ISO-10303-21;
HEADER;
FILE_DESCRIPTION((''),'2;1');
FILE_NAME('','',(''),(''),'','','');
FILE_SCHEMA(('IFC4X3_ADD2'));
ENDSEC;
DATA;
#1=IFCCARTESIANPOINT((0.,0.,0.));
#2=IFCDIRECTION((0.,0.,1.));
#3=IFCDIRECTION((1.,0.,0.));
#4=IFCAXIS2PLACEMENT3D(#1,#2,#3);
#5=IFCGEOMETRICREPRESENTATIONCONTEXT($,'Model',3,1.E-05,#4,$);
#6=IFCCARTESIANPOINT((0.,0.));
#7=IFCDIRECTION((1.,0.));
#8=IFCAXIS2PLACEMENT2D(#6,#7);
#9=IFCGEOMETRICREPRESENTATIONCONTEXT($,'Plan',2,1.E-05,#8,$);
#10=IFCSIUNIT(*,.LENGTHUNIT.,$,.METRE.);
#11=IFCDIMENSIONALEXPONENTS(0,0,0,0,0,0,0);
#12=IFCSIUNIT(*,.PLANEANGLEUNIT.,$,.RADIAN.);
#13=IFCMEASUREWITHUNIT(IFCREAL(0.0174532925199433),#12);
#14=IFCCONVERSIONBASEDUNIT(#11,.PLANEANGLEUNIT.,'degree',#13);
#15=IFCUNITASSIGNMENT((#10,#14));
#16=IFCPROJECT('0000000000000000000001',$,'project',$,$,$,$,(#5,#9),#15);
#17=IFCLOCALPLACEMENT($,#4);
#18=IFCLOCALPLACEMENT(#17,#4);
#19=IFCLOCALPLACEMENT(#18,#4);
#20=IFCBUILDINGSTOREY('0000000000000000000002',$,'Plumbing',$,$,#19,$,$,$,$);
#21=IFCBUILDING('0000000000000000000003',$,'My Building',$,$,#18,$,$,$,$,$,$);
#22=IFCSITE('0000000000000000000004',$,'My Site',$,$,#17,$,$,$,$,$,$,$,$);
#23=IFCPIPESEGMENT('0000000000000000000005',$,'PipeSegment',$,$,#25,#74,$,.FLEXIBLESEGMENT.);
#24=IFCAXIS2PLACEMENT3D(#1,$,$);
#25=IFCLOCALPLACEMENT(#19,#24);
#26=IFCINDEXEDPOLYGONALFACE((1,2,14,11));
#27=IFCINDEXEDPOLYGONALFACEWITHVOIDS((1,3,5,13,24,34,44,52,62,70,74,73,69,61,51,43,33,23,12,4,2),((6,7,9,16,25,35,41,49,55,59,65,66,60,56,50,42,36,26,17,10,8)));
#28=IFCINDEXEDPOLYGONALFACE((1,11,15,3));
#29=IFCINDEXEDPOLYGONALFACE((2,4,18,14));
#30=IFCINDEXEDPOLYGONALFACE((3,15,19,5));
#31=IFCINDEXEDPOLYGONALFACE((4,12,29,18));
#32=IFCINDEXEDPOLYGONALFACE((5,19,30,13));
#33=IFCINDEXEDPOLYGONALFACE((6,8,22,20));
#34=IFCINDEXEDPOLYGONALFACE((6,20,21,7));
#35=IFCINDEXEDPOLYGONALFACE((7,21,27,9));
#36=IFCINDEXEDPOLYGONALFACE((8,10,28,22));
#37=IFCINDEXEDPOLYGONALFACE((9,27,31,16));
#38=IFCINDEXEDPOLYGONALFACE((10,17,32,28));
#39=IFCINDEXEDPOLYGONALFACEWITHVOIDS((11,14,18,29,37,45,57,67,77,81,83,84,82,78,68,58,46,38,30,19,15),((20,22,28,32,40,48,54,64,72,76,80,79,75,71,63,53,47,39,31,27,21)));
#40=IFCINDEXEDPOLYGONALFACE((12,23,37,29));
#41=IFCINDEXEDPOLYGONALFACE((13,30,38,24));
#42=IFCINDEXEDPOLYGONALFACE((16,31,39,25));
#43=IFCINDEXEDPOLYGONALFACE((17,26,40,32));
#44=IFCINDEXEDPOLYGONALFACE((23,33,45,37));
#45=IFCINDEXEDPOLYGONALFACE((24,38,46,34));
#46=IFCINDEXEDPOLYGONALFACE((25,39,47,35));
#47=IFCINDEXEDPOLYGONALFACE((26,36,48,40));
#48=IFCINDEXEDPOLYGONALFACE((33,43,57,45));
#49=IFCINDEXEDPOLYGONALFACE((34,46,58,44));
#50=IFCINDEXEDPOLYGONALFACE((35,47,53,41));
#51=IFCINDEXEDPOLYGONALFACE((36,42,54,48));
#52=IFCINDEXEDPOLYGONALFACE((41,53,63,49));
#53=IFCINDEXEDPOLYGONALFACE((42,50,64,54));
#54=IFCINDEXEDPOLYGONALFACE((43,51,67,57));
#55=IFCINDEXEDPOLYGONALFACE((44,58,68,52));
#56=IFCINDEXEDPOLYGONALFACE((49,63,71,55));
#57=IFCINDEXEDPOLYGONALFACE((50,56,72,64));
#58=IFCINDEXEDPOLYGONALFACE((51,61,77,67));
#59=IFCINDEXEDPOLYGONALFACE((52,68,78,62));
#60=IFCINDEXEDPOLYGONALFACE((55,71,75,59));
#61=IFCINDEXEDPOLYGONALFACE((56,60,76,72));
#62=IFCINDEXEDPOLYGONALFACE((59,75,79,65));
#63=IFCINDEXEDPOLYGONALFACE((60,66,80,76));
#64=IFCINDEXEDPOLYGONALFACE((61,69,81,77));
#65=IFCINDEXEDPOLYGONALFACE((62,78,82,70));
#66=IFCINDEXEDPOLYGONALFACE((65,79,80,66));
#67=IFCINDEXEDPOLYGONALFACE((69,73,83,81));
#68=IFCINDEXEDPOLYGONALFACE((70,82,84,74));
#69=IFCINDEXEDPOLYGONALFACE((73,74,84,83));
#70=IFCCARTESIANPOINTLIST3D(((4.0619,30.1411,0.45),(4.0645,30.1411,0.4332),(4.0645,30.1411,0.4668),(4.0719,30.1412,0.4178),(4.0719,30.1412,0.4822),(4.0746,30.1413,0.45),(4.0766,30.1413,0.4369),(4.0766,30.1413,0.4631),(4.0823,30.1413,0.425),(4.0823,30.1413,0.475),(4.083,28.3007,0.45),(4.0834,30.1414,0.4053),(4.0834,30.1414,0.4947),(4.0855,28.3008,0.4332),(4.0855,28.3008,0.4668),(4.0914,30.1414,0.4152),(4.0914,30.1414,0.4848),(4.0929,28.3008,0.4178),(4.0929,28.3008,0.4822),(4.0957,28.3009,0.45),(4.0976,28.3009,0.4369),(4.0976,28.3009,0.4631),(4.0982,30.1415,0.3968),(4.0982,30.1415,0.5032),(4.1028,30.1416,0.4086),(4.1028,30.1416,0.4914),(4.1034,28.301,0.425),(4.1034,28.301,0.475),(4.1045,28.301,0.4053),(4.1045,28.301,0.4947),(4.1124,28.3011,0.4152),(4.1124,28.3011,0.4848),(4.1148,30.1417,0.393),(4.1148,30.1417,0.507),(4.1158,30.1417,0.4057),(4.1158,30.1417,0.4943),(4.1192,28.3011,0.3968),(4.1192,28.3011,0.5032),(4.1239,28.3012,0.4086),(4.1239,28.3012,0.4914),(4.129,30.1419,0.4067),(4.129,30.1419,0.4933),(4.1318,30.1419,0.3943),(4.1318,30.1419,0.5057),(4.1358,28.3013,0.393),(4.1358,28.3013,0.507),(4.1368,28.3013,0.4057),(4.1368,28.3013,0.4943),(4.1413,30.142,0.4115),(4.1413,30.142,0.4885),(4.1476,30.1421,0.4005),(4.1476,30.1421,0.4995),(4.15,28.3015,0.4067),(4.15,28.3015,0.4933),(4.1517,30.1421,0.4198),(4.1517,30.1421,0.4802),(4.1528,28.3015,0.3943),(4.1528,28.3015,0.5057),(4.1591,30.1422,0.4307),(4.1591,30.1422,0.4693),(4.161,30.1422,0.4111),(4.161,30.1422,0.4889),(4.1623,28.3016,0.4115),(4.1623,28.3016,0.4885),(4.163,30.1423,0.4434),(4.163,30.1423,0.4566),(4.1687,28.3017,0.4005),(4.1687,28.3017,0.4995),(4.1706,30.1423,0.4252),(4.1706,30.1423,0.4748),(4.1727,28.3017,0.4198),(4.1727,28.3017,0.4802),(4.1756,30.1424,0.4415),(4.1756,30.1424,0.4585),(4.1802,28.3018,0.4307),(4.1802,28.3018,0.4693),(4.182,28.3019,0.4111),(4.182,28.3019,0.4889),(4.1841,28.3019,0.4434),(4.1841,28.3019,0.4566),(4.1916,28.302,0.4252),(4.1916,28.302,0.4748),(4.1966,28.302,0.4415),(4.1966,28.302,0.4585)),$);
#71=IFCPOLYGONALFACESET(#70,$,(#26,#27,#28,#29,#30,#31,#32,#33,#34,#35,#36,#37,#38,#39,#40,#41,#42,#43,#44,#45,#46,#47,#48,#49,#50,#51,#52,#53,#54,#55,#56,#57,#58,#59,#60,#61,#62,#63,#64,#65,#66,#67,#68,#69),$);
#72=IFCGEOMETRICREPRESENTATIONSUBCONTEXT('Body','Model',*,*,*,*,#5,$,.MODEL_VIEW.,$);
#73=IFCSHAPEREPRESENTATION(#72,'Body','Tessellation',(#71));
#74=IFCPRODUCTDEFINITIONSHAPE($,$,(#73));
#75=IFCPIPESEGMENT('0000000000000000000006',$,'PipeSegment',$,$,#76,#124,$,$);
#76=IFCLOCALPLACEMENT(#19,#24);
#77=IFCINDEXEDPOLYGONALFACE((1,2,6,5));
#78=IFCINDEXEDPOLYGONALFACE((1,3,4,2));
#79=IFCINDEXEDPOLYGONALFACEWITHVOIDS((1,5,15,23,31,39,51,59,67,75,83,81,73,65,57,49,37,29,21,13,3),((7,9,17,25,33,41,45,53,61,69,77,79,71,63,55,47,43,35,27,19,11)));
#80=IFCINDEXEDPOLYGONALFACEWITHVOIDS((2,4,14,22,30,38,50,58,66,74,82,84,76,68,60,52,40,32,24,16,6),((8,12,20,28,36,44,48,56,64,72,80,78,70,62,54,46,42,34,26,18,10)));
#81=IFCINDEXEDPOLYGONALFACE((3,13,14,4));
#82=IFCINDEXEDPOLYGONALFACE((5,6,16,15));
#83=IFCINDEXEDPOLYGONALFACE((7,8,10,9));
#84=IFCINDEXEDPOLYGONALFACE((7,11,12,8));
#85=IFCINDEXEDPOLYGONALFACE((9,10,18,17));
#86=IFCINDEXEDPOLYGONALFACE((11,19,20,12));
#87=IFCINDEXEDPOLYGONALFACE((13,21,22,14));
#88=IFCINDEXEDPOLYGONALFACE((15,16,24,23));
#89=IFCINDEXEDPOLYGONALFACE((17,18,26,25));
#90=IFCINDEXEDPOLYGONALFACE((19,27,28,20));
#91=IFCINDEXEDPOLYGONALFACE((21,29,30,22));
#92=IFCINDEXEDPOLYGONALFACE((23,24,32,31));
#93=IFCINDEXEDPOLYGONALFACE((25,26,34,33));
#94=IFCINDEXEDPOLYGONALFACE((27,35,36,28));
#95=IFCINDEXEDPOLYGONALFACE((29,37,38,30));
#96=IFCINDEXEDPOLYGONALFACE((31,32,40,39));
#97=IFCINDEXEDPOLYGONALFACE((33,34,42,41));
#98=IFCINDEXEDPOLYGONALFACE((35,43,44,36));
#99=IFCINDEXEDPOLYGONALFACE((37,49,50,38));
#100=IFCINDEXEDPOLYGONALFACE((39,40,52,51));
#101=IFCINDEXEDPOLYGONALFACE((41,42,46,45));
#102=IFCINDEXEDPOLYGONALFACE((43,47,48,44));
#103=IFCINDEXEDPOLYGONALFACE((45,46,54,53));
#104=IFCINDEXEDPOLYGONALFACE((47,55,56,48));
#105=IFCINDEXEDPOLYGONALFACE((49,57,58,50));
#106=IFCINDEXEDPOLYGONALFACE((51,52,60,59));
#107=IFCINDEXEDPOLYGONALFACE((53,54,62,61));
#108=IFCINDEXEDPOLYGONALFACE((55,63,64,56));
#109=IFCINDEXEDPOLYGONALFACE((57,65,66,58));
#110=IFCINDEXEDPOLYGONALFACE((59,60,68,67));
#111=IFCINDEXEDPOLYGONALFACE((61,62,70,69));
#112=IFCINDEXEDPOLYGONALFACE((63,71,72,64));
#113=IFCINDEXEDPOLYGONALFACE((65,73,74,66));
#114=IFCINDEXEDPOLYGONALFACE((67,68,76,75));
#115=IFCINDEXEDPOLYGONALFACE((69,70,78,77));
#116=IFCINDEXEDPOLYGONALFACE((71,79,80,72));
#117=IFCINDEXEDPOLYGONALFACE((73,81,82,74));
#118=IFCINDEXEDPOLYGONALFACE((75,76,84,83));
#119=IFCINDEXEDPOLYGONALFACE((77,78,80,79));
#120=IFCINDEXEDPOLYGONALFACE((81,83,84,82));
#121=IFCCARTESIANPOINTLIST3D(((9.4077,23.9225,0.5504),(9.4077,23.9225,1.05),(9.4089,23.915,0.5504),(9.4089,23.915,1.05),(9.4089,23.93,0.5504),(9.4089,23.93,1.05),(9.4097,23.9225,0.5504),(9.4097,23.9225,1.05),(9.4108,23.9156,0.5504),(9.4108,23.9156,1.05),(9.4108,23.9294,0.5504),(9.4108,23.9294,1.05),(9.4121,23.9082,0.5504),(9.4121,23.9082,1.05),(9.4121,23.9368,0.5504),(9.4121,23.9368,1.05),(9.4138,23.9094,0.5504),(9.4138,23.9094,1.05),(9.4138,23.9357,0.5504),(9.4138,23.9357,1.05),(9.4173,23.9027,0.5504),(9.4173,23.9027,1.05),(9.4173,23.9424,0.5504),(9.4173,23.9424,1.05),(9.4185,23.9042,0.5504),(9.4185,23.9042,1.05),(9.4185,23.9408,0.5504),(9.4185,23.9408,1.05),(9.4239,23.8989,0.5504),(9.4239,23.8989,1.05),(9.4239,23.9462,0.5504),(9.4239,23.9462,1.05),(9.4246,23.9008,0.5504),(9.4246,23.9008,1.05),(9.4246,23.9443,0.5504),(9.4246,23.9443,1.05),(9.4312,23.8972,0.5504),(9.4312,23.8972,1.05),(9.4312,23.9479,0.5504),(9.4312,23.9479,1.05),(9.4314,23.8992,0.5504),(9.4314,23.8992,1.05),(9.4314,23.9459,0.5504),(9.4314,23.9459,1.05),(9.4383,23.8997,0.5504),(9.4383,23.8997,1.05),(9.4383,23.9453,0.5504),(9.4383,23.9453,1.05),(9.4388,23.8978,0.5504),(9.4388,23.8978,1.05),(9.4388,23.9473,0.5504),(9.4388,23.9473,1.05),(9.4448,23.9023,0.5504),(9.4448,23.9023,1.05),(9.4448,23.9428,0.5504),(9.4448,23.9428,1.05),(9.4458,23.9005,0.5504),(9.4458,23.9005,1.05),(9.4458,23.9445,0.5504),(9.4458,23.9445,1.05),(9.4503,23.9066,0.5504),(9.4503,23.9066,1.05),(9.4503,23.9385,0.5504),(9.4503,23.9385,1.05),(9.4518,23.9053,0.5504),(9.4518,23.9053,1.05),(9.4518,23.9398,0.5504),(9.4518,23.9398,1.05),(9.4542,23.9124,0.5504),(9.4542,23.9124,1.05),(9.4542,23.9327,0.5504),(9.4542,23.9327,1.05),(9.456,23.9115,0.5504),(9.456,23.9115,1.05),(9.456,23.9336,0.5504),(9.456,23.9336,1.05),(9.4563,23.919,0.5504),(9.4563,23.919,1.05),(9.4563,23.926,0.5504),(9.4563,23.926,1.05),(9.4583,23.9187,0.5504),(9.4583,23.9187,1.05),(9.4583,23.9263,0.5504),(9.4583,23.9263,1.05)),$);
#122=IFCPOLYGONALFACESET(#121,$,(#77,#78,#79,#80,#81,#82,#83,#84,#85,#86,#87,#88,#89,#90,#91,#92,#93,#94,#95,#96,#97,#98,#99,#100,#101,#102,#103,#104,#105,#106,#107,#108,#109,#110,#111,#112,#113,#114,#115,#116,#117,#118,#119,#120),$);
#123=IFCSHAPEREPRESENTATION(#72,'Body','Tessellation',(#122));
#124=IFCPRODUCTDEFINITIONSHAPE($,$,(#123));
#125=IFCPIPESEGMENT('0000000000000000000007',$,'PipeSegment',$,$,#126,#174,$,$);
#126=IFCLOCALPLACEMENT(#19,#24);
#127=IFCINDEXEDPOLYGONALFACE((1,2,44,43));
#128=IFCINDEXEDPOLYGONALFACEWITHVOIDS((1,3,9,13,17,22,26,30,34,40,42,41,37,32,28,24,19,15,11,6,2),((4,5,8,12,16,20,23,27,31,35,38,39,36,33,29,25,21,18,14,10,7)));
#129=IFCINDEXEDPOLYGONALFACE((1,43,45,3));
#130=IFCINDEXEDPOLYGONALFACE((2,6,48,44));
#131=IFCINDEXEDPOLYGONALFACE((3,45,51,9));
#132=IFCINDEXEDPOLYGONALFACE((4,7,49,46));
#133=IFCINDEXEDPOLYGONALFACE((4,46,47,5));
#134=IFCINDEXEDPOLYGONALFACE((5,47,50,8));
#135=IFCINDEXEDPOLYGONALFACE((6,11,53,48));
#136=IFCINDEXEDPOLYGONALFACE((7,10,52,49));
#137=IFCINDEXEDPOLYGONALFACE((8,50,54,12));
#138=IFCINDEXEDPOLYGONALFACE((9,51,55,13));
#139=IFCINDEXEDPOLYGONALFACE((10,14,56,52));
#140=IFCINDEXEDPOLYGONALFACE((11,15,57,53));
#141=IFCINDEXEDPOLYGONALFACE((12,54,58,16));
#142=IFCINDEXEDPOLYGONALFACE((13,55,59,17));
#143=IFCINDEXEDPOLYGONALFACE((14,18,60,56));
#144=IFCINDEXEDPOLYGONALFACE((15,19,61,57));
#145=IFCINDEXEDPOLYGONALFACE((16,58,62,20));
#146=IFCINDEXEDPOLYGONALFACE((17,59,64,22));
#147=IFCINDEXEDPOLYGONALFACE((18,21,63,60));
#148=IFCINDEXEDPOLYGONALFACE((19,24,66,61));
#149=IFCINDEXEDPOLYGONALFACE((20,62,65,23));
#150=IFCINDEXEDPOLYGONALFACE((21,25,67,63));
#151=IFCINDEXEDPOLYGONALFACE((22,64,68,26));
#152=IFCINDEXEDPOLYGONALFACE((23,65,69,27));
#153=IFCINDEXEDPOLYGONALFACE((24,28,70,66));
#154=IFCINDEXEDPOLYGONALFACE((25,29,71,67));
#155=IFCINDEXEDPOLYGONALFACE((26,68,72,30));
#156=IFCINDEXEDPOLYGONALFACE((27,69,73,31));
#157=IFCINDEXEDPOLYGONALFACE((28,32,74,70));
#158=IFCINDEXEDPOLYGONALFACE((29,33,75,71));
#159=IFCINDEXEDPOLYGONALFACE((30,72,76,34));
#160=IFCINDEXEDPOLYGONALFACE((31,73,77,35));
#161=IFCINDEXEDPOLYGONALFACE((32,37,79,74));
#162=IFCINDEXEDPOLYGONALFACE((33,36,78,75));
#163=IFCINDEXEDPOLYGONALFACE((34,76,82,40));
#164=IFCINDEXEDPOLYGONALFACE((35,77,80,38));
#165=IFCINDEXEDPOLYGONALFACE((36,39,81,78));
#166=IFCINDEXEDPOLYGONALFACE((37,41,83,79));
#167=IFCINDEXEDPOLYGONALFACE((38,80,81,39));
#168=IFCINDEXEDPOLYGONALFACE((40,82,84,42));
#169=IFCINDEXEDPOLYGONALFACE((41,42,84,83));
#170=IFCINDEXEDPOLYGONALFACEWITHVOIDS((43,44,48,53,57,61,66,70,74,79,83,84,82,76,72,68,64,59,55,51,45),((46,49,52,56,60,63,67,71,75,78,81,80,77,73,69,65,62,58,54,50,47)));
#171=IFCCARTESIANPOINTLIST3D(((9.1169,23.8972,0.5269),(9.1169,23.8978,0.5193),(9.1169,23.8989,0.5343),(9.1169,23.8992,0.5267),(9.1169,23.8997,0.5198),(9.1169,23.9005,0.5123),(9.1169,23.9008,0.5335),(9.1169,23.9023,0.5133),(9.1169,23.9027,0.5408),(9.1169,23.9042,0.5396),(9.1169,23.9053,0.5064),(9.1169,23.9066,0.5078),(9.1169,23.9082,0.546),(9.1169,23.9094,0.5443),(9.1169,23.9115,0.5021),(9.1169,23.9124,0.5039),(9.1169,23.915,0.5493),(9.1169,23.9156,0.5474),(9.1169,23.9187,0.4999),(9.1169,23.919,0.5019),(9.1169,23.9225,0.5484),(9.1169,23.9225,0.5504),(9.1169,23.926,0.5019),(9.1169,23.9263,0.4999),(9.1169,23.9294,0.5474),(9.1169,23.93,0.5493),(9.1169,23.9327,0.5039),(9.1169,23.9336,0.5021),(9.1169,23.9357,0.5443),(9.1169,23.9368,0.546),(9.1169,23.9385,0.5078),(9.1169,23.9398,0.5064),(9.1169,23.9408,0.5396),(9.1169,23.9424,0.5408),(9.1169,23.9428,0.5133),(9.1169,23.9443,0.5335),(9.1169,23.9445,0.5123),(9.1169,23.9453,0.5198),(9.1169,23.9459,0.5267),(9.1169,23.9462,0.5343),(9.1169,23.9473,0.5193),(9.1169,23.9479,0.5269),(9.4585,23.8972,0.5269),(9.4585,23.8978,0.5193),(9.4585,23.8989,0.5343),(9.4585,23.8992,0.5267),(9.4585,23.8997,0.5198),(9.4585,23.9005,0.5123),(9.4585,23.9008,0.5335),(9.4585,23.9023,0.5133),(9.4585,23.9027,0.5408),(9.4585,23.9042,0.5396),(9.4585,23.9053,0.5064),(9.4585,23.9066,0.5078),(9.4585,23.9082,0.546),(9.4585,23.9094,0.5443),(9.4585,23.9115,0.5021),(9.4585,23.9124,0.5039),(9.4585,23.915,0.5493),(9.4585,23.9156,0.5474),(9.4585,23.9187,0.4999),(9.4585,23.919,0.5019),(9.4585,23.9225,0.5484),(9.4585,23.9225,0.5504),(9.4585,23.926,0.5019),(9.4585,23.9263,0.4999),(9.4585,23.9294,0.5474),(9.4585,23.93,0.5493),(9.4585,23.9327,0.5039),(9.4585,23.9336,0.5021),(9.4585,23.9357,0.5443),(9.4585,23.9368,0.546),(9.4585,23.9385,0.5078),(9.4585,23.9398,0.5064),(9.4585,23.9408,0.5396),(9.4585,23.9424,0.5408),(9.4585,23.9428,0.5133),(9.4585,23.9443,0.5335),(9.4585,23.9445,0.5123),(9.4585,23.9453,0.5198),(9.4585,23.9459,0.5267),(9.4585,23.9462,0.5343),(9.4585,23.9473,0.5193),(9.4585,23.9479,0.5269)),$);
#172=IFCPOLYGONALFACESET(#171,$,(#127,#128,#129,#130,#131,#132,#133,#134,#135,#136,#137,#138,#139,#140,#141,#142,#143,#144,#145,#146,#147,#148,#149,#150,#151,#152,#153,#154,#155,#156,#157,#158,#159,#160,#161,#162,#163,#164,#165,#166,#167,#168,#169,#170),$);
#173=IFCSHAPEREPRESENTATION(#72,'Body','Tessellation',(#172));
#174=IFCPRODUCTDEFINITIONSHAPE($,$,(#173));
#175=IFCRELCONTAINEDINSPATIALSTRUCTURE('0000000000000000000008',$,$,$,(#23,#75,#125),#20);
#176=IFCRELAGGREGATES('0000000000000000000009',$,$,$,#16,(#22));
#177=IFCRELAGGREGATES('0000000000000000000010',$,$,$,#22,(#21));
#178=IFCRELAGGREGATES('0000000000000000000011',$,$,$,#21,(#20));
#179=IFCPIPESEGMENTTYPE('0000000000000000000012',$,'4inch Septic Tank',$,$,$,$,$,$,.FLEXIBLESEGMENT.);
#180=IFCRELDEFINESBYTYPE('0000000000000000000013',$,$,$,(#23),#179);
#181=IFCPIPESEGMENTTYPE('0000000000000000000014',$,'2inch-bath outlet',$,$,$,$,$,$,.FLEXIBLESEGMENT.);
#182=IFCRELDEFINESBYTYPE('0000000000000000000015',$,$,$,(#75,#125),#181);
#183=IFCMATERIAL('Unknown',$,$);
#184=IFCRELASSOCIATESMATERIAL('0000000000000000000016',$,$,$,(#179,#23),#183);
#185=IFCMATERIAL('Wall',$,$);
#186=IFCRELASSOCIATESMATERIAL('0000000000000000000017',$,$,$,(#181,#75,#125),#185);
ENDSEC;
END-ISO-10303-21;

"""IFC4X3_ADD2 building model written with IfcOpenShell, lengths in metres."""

from ifc_helpers import new_model, entity, si_unit, converted_unit, frame, origin_with_axes, origin_2d_with_axis, place, context, subcontext, project, spatial, hollow_circle, extrude, material, material_profile, profile_set, profile_usage, type_object, element, save


model = new_model("IFC4X3_ADD2")

# Units and contexts
model_context = context("Model", 3, precision=1e-05, world=origin_with_axes())
plan_context = context("Plan", 2, precision=1e-05, world=origin_2d_with_axis())
body_context = subcontext(model_context, "Body", "Model", "MODEL_VIEW")
ifc_project = project(units=[si_unit("LENGTHUNIT", "METRE"), converted_unit("PLANEANGLEUNIT", "degree", entity("IfcReal", 0.0174532925199433), si_unit("PLANEANGLEUNIT", "RADIAN"), dimensions=[0, 0, 0, 0, 0, 0, 0])], contexts=[model_context, plan_context])

# Site, building, storey
site_placement = place(None, origin_with_axes())
site = spatial("IfcSite", under=ifc_project, at=site_placement, Name="My Site")
building_placement = place(site_placement, origin_with_axes())
building = spatial("IfcBuilding", under=site, at=building_placement, Name="My Building")
storey_placement = place(building_placement, origin_with_axes())
storey = spatial("IfcBuildingStorey", under=building, at=storey_placement, Name="Plumbing")

# Pipe segments
ifc_material_1 = material(Name="Unknown")
ifc_material_profile_1 = material_profile(ifc_material_1, hollow_circle(Radius=0.0571, WallThickness=0.0127))
ifc_profile_set_1 = profile_set([ifc_material_profile_1], Name="blackwater")
ifc_material_profile_2 = material_profile(ifc_material_1, hollow_circle(Radius=0.0571, WallThickness=0.0127))
ifc_profile_set_2 = profile_set([ifc_material_profile_2], Name="blackwater")
pipe_segment_type_1 = type_object("IfcPipeSegmentType", Name="4inch Septic Tank", PredefinedType="FLEXIBLESEGMENT", material=ifc_profile_set_2)
ifc_profile_usage_1 = profile_usage(ifc_profile_set_1, cardinal=5)
pipe_segment_1_placement = place(storey_placement, frame((4.1191, 30.1418, 0.45), z_axis=(0.011434, -0.999935, 0.0), x_axis=(-0.999935, -0.011434, 0.0)))
element("IfcPipeSegment", 1, at=pipe_segment_1_placement, inside=storey, type_object=pipe_segment_type_1, material=ifc_profile_usage_1, Name="PipeSegment", PredefinedType="FLEXIBLESEGMENT", context=body_context, shape_type="SweptSolid", body=[
    extrude(hollow_circle(Radius=0.0571, WallThickness=0.0127), origin_with_axes(), (0.0, 0.0, 1.0), 1.8405),
])
ifc_material_2 = material(Name="Wall")
ifc_material_profile_3 = material_profile(ifc_material_2, hollow_circle(Radius=0.0254, WallThickness=0.002))
ifc_profile_set_3 = profile_set([ifc_material_profile_3], Name="graywater")
ifc_profile_usage_2 = profile_usage(ifc_profile_set_3)
ifc_material_profile_4 = material_profile(ifc_material_2, hollow_circle(Radius=0.0254, WallThickness=0.002))
ifc_profile_set_4 = profile_set([ifc_material_profile_4], Name="graywater")
pipe_segment_type_2 = type_object("IfcPipeSegmentType", Name="2inch-bath outlet", PredefinedType="FLEXIBLESEGMENT", material=ifc_profile_set_4)
pipe_segment_2_placement = place(storey_placement, frame((9.4331, 23.9225, 0.5504), z_axis=(0.0, 0.0, 1.0), x_axis=(-1.0, 0.0, 0.0)))
element("IfcPipeSegment", 2, at=pipe_segment_2_placement, inside=storey, type_object=pipe_segment_type_2, material=ifc_profile_usage_2, Name="PipeSegment", context=body_context, shape_type="SweptSolid", body=[
    extrude(hollow_circle(Radius=0.0254, WallThickness=0.002), origin_with_axes(), (0.0, 0.0, 1.0), 0.4996),
])
ifc_profile_usage_3 = profile_usage(ifc_profile_set_3)
pipe_segment_3_placement = place(storey_placement, frame((9.1169, 23.9225, 0.525), z_axis=(1.0, 0.0, 0.0), x_axis=(0.0, 0.0, 1.0)))
element("IfcPipeSegment", 3, at=pipe_segment_3_placement, inside=storey, type_object=pipe_segment_type_2, material=ifc_profile_usage_3, Name="PipeSegment", context=body_context, shape_type="SweptSolid", body=[
    extrude(hollow_circle(Radius=0.0254, WallThickness=0.002), origin_with_axes(), (0.0, 0.0, 1.0), 0.3416),
])

save(model, "model.ifc")
